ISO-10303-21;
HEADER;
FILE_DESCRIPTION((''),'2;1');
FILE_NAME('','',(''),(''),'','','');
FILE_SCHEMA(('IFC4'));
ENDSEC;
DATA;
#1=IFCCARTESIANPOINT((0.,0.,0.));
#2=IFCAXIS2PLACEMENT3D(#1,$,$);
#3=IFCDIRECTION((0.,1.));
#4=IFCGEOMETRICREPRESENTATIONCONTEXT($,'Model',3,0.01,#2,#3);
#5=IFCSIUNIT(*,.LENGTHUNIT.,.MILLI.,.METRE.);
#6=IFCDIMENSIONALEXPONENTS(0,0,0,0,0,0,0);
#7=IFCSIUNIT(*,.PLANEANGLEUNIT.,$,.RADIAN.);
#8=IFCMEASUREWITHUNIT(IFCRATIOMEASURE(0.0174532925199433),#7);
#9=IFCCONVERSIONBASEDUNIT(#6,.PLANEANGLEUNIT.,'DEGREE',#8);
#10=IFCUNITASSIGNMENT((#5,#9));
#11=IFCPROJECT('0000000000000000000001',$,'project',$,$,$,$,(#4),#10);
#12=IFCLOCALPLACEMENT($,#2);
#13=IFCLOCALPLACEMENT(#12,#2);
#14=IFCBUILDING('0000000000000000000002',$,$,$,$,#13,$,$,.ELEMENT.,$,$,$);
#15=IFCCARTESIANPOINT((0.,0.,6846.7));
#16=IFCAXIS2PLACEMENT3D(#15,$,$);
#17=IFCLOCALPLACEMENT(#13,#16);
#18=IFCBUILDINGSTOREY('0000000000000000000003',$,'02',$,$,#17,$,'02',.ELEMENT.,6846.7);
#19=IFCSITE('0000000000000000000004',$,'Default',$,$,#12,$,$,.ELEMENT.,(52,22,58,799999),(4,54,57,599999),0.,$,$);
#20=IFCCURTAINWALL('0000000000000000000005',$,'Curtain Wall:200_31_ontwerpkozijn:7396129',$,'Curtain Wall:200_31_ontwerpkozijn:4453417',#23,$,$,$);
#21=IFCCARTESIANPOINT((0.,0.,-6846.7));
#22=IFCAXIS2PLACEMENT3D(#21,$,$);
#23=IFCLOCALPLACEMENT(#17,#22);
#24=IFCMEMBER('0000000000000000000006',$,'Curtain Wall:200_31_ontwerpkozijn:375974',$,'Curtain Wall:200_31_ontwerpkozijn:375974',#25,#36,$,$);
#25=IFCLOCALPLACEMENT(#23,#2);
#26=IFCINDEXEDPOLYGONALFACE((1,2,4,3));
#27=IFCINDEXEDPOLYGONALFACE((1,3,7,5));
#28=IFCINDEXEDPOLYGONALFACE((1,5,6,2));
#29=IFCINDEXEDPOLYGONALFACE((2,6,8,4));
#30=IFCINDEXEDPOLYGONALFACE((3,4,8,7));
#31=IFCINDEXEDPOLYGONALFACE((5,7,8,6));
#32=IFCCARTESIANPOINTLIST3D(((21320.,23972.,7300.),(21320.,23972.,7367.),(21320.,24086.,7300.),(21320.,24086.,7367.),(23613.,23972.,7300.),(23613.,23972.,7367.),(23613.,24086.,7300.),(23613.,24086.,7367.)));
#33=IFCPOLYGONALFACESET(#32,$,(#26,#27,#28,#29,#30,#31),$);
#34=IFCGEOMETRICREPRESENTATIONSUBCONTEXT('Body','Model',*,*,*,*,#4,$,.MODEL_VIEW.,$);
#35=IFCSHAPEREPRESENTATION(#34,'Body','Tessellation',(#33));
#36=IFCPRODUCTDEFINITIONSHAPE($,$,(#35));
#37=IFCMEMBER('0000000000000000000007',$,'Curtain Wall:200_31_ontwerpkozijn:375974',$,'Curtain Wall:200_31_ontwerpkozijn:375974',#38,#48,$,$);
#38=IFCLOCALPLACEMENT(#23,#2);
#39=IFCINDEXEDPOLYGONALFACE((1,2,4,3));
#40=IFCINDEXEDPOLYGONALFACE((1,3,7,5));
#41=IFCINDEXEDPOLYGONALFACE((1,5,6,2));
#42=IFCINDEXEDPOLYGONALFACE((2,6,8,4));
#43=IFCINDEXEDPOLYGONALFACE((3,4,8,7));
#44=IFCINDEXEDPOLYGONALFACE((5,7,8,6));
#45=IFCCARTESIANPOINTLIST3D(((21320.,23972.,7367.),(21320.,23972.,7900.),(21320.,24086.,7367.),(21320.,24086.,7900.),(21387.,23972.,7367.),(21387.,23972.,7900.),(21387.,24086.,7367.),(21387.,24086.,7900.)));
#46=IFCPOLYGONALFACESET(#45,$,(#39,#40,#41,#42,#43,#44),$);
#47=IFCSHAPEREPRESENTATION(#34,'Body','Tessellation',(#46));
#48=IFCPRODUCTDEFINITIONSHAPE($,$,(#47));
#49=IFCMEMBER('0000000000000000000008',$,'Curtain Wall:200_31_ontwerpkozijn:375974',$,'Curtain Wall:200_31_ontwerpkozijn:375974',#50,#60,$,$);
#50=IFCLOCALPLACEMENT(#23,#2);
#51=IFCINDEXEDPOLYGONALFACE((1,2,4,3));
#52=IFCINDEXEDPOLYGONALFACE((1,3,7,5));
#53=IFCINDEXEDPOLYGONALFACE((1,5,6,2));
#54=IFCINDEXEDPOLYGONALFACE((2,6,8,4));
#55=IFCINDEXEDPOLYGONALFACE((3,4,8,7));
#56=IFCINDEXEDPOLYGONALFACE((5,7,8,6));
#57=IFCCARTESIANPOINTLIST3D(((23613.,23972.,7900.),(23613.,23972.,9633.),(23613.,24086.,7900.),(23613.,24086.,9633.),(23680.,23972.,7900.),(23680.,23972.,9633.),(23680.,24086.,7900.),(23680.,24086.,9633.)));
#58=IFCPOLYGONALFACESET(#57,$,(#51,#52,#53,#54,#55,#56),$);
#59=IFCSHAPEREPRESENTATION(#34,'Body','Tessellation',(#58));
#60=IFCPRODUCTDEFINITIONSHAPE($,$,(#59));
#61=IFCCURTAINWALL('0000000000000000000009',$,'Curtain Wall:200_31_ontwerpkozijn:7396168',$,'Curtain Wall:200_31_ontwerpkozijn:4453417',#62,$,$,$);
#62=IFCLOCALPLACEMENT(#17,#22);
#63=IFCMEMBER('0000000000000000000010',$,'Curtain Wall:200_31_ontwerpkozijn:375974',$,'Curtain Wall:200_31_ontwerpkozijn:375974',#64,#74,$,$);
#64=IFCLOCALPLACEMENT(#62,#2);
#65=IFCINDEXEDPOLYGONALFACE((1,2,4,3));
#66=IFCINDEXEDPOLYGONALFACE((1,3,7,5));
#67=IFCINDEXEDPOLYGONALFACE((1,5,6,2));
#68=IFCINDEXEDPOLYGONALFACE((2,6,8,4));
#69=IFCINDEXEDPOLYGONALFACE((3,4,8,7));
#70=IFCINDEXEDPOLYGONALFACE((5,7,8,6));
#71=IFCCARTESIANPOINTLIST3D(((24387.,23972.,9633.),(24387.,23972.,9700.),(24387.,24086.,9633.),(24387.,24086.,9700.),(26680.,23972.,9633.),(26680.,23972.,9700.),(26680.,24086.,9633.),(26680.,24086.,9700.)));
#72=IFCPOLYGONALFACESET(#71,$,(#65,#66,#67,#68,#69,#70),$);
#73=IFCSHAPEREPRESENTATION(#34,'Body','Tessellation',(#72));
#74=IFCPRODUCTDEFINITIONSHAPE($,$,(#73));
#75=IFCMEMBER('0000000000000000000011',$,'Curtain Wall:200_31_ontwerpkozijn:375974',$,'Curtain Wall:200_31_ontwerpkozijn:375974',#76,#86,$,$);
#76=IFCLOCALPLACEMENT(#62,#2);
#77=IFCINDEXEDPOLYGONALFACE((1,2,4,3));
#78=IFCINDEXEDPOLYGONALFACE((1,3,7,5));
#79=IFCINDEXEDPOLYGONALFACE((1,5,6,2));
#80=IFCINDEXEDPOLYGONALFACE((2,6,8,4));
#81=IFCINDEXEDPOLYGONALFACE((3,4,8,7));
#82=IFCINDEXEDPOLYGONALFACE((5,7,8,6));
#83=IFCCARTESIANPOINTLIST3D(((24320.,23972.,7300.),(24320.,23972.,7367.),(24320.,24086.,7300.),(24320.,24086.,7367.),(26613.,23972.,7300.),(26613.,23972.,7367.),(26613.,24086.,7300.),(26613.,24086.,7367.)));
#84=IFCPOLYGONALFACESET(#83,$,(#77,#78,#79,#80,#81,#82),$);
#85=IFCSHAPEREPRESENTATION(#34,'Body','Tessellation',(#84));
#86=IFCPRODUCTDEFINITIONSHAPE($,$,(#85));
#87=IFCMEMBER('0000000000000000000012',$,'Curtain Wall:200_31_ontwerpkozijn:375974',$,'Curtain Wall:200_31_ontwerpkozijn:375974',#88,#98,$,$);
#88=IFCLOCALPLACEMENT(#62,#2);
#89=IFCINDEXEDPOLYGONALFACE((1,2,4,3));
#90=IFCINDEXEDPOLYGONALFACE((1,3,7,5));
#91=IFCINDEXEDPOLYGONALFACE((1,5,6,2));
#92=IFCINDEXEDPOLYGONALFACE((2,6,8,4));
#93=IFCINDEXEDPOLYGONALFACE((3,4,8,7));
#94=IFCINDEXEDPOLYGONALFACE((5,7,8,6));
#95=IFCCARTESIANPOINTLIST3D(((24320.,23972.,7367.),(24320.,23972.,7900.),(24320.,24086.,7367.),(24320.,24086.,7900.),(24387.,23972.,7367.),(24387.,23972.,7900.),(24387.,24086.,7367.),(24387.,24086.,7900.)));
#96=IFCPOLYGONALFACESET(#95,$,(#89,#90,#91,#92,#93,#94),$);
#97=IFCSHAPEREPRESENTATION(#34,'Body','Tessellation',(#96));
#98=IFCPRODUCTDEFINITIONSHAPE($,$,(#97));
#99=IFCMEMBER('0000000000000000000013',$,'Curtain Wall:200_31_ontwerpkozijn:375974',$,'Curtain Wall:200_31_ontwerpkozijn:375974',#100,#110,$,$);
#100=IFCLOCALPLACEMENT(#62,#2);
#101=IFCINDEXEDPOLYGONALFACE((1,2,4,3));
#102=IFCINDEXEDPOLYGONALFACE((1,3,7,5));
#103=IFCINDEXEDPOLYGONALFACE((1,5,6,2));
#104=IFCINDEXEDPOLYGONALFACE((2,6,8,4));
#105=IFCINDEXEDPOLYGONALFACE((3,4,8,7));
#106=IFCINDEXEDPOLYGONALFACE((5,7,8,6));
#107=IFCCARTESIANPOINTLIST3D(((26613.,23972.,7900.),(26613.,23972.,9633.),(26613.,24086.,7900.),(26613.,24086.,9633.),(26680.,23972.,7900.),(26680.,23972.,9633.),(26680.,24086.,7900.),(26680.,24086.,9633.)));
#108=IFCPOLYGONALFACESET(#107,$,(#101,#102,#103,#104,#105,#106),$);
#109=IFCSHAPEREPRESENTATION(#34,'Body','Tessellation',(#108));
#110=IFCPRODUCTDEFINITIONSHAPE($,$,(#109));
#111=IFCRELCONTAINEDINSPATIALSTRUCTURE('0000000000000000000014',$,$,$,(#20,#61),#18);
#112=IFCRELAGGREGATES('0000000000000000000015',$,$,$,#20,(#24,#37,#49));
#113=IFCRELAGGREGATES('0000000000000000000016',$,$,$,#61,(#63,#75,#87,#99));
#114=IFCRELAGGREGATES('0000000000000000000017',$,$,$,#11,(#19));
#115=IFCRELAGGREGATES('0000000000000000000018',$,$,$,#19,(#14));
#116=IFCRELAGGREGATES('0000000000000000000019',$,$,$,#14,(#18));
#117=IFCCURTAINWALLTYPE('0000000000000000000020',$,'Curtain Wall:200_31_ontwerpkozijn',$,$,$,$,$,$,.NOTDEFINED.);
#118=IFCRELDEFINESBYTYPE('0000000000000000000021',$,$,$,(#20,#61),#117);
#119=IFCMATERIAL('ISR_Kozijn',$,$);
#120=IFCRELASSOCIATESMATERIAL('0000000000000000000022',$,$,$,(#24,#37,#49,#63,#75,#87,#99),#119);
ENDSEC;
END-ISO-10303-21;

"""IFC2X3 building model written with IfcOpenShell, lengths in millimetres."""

from ifc_helpers import new_model, entity, si_unit, converted_unit, direction, frame, frame_2d, origin, origin_2d_with_axis, place, context, subcontext, project, spatial, rectangle, extrude, material, type_object, element, aggregate, save


model = new_model("IFC2X3")

# Units and contexts
model_context = context("Model", 3, precision=0.01, world=origin(), true_north=direction((0.0, 1.0)))
body_context = subcontext(model_context, "Body", "Model", "MODEL_VIEW")
ifc_project = project(units=[si_unit("LENGTHUNIT", "METRE", prefix="MILLI"), converted_unit("PLANEANGLEUNIT", "DEGREE", entity("IfcRatioMeasure", 0.0174532925199433), si_unit("PLANEANGLEUNIT", "RADIAN"), dimensions=[0, 0, 0, 0, 0, 0, 0])], contexts=[model_context])

# Site, building, storey
site_placement = place(None, origin())
site = spatial("IfcSite", under=ifc_project, at=site_placement, Name="Default", CompositionType="ELEMENT", RefLatitude=(52, 22, 58, 799999), RefLongitude=(4, 54, 57, 599999), RefElevation=0.0)
building_placement = place(site_placement, origin())
building = spatial("IfcBuilding", under=site, at=building_placement, CompositionType="ELEMENT")
storey_placement = place(building_placement, frame((0.0, 0.0, 6846.7)))
storey = spatial("IfcBuildingStorey", under=building, at=storey_placement, Name="02", LongName="02", CompositionType="ELEMENT", Elevation=6846.7)

# Curtain walls, members
curtain_wall_type = type_object("IfcCurtainWallType", Name="Curtain Wall:200_31_ontwerpkozijn", PredefinedType="NOTDEFINED")
ifc_material = material(Name="ISR_Kozijn")
curtain_wall_1_placement = place(storey_placement, frame((0.0, 0.0, -6846.7)))
curtain_wall_1 = element("IfcCurtainWall", 1, at=curtain_wall_1_placement, inside=storey, type_object=curtain_wall_type, Name="Curtain Wall:200_31_ontwerpkozijn:7396129", ObjectType="Curtain Wall:200_31_ontwerpkozijn:4453417")
member_1_placement = place(curtain_wall_1_placement, origin())
member_1 = element("IfcMember", 2, at=member_1_placement, material=ifc_material, Name="Curtain Wall:200_31_ontwerpkozijn:375974", ObjectType="Curtain Wall:200_31_ontwerpkozijn:375974", context=body_context, shape_type="SweptSolid", body=[
    extrude(rectangle(XDim=67.0, YDim=114.0, at=frame_2d((0.0, 0.0), x_axis=(1.0, 0.0))), frame((23613.0, 24029.0, 7333.5), z_axis=(-1.0, 0.0, 0.0), x_axis=(0.0, 0.0, -1.0)), (0.0, 0.0, 1.0), 2293.0),
])
member_2_placement = place(curtain_wall_1_placement, origin())
member_2 = element("IfcMember", 3, at=member_2_placement, material=ifc_material, Name="Curtain Wall:200_31_ontwerpkozijn:375974", ObjectType="Curtain Wall:200_31_ontwerpkozijn:375974", context=body_context, shape_type="SweptSolid", body=[
    extrude(rectangle(XDim=67.0, YDim=114.0, at=origin_2d_with_axis()), frame((21353.5, 24029.0, 7367.0), z_axis=(0.0, 0.0, 1.0), x_axis=(-1.0, 0.0, 0.0)), (0.0, 0.0, 1.0), 533.0),
])
member_3_placement = place(curtain_wall_1_placement, origin())
member_3 = element("IfcMember", 4, at=member_3_placement, material=ifc_material, Name="Curtain Wall:200_31_ontwerpkozijn:375974", ObjectType="Curtain Wall:200_31_ontwerpkozijn:375974", context=body_context, shape_type="SweptSolid", body=[
    extrude(rectangle(XDim=67.0, YDim=114.0, at=origin_2d_with_axis()), frame((23646.5, 24029.0, 9633.0), z_axis=(0.0, 0.0, -1.0), x_axis=(-1.0, 0.0, 0.0)), (0.0, 0.0, 1.0), 1733.0),
])
aggregate(curtain_wall_1, [member_1, member_2, member_3])
curtain_wall_2_placement = place(storey_placement, frame((0.0, 0.0, -6846.7)))
curtain_wall_2 = element("IfcCurtainWall", 5, at=curtain_wall_2_placement, inside=storey, type_object=curtain_wall_type, Name="Curtain Wall:200_31_ontwerpkozijn:7396168", ObjectType="Curtain Wall:200_31_ontwerpkozijn:4453417")
member_4_placement = place(curtain_wall_2_placement, origin())
member_4 = element("IfcMember", 6, at=member_4_placement, material=ifc_material, Name="Curtain Wall:200_31_ontwerpkozijn:375974", ObjectType="Curtain Wall:200_31_ontwerpkozijn:375974", context=body_context, shape_type="SweptSolid", body=[
    extrude(rectangle(XDim=67.0, YDim=114.0, at=frame_2d((0.0, 0.0), x_axis=(1.0, 0.0))), frame((24387.0, 24029.0, 9666.5), z_axis=(1.0, 0.0, 0.0), x_axis=(0.0, 0.0, -1.0)), (0.0, 0.0, 1.0), 2293.0),
])
member_5_placement = place(curtain_wall_2_placement, origin())
member_5 = element("IfcMember", 7, at=member_5_placement, material=ifc_material, Name="Curtain Wall:200_31_ontwerpkozijn:375974", ObjectType="Curtain Wall:200_31_ontwerpkozijn:375974", context=body_context, shape_type="SweptSolid", body=[
    extrude(rectangle(XDim=67.0, YDim=114.0, at=frame_2d((0.0, 0.0), x_axis=(1.0, 0.0))), frame((26613.0, 24029.0, 7333.5), z_axis=(-1.0, 0.0, 0.0), x_axis=(0.0, 0.0, -1.0)), (0.0, 0.0, 1.0), 2293.0),
])
member_6_placement = place(curtain_wall_2_placement, origin())
member_6 = element("IfcMember", 8, at=member_6_placement, material=ifc_material, Name="Curtain Wall:200_31_ontwerpkozijn:375974", ObjectType="Curtain Wall:200_31_ontwerpkozijn:375974", context=body_context, shape_type="SweptSolid", body=[
    extrude(rectangle(XDim=67.0, YDim=114.0, at=origin_2d_with_axis()), frame((24353.5, 24029.0, 7367.0), z_axis=(0.0, 0.0, 1.0), x_axis=(-1.0, 0.0, 0.0)), (0.0, 0.0, 1.0), 533.0),
])
member_7_placement = place(curtain_wall_2_placement, origin())
member_7 = element("IfcMember", 9, at=member_7_placement, material=ifc_material, Name="Curtain Wall:200_31_ontwerpkozijn:375974", ObjectType="Curtain Wall:200_31_ontwerpkozijn:375974", context=body_context, shape_type="SweptSolid", body=[
    extrude(rectangle(XDim=67.0, YDim=114.0, at=origin_2d_with_axis()), frame((26646.5, 24029.0, 9633.0), z_axis=(0.0, 0.0, -1.0), x_axis=(-1.0, 0.0, 0.0)), (0.0, 0.0, 1.0), 1733.0),
])
aggregate(curtain_wall_2, [member_4, member_5, member_6, member_7])

save(model, "model.ifc")
